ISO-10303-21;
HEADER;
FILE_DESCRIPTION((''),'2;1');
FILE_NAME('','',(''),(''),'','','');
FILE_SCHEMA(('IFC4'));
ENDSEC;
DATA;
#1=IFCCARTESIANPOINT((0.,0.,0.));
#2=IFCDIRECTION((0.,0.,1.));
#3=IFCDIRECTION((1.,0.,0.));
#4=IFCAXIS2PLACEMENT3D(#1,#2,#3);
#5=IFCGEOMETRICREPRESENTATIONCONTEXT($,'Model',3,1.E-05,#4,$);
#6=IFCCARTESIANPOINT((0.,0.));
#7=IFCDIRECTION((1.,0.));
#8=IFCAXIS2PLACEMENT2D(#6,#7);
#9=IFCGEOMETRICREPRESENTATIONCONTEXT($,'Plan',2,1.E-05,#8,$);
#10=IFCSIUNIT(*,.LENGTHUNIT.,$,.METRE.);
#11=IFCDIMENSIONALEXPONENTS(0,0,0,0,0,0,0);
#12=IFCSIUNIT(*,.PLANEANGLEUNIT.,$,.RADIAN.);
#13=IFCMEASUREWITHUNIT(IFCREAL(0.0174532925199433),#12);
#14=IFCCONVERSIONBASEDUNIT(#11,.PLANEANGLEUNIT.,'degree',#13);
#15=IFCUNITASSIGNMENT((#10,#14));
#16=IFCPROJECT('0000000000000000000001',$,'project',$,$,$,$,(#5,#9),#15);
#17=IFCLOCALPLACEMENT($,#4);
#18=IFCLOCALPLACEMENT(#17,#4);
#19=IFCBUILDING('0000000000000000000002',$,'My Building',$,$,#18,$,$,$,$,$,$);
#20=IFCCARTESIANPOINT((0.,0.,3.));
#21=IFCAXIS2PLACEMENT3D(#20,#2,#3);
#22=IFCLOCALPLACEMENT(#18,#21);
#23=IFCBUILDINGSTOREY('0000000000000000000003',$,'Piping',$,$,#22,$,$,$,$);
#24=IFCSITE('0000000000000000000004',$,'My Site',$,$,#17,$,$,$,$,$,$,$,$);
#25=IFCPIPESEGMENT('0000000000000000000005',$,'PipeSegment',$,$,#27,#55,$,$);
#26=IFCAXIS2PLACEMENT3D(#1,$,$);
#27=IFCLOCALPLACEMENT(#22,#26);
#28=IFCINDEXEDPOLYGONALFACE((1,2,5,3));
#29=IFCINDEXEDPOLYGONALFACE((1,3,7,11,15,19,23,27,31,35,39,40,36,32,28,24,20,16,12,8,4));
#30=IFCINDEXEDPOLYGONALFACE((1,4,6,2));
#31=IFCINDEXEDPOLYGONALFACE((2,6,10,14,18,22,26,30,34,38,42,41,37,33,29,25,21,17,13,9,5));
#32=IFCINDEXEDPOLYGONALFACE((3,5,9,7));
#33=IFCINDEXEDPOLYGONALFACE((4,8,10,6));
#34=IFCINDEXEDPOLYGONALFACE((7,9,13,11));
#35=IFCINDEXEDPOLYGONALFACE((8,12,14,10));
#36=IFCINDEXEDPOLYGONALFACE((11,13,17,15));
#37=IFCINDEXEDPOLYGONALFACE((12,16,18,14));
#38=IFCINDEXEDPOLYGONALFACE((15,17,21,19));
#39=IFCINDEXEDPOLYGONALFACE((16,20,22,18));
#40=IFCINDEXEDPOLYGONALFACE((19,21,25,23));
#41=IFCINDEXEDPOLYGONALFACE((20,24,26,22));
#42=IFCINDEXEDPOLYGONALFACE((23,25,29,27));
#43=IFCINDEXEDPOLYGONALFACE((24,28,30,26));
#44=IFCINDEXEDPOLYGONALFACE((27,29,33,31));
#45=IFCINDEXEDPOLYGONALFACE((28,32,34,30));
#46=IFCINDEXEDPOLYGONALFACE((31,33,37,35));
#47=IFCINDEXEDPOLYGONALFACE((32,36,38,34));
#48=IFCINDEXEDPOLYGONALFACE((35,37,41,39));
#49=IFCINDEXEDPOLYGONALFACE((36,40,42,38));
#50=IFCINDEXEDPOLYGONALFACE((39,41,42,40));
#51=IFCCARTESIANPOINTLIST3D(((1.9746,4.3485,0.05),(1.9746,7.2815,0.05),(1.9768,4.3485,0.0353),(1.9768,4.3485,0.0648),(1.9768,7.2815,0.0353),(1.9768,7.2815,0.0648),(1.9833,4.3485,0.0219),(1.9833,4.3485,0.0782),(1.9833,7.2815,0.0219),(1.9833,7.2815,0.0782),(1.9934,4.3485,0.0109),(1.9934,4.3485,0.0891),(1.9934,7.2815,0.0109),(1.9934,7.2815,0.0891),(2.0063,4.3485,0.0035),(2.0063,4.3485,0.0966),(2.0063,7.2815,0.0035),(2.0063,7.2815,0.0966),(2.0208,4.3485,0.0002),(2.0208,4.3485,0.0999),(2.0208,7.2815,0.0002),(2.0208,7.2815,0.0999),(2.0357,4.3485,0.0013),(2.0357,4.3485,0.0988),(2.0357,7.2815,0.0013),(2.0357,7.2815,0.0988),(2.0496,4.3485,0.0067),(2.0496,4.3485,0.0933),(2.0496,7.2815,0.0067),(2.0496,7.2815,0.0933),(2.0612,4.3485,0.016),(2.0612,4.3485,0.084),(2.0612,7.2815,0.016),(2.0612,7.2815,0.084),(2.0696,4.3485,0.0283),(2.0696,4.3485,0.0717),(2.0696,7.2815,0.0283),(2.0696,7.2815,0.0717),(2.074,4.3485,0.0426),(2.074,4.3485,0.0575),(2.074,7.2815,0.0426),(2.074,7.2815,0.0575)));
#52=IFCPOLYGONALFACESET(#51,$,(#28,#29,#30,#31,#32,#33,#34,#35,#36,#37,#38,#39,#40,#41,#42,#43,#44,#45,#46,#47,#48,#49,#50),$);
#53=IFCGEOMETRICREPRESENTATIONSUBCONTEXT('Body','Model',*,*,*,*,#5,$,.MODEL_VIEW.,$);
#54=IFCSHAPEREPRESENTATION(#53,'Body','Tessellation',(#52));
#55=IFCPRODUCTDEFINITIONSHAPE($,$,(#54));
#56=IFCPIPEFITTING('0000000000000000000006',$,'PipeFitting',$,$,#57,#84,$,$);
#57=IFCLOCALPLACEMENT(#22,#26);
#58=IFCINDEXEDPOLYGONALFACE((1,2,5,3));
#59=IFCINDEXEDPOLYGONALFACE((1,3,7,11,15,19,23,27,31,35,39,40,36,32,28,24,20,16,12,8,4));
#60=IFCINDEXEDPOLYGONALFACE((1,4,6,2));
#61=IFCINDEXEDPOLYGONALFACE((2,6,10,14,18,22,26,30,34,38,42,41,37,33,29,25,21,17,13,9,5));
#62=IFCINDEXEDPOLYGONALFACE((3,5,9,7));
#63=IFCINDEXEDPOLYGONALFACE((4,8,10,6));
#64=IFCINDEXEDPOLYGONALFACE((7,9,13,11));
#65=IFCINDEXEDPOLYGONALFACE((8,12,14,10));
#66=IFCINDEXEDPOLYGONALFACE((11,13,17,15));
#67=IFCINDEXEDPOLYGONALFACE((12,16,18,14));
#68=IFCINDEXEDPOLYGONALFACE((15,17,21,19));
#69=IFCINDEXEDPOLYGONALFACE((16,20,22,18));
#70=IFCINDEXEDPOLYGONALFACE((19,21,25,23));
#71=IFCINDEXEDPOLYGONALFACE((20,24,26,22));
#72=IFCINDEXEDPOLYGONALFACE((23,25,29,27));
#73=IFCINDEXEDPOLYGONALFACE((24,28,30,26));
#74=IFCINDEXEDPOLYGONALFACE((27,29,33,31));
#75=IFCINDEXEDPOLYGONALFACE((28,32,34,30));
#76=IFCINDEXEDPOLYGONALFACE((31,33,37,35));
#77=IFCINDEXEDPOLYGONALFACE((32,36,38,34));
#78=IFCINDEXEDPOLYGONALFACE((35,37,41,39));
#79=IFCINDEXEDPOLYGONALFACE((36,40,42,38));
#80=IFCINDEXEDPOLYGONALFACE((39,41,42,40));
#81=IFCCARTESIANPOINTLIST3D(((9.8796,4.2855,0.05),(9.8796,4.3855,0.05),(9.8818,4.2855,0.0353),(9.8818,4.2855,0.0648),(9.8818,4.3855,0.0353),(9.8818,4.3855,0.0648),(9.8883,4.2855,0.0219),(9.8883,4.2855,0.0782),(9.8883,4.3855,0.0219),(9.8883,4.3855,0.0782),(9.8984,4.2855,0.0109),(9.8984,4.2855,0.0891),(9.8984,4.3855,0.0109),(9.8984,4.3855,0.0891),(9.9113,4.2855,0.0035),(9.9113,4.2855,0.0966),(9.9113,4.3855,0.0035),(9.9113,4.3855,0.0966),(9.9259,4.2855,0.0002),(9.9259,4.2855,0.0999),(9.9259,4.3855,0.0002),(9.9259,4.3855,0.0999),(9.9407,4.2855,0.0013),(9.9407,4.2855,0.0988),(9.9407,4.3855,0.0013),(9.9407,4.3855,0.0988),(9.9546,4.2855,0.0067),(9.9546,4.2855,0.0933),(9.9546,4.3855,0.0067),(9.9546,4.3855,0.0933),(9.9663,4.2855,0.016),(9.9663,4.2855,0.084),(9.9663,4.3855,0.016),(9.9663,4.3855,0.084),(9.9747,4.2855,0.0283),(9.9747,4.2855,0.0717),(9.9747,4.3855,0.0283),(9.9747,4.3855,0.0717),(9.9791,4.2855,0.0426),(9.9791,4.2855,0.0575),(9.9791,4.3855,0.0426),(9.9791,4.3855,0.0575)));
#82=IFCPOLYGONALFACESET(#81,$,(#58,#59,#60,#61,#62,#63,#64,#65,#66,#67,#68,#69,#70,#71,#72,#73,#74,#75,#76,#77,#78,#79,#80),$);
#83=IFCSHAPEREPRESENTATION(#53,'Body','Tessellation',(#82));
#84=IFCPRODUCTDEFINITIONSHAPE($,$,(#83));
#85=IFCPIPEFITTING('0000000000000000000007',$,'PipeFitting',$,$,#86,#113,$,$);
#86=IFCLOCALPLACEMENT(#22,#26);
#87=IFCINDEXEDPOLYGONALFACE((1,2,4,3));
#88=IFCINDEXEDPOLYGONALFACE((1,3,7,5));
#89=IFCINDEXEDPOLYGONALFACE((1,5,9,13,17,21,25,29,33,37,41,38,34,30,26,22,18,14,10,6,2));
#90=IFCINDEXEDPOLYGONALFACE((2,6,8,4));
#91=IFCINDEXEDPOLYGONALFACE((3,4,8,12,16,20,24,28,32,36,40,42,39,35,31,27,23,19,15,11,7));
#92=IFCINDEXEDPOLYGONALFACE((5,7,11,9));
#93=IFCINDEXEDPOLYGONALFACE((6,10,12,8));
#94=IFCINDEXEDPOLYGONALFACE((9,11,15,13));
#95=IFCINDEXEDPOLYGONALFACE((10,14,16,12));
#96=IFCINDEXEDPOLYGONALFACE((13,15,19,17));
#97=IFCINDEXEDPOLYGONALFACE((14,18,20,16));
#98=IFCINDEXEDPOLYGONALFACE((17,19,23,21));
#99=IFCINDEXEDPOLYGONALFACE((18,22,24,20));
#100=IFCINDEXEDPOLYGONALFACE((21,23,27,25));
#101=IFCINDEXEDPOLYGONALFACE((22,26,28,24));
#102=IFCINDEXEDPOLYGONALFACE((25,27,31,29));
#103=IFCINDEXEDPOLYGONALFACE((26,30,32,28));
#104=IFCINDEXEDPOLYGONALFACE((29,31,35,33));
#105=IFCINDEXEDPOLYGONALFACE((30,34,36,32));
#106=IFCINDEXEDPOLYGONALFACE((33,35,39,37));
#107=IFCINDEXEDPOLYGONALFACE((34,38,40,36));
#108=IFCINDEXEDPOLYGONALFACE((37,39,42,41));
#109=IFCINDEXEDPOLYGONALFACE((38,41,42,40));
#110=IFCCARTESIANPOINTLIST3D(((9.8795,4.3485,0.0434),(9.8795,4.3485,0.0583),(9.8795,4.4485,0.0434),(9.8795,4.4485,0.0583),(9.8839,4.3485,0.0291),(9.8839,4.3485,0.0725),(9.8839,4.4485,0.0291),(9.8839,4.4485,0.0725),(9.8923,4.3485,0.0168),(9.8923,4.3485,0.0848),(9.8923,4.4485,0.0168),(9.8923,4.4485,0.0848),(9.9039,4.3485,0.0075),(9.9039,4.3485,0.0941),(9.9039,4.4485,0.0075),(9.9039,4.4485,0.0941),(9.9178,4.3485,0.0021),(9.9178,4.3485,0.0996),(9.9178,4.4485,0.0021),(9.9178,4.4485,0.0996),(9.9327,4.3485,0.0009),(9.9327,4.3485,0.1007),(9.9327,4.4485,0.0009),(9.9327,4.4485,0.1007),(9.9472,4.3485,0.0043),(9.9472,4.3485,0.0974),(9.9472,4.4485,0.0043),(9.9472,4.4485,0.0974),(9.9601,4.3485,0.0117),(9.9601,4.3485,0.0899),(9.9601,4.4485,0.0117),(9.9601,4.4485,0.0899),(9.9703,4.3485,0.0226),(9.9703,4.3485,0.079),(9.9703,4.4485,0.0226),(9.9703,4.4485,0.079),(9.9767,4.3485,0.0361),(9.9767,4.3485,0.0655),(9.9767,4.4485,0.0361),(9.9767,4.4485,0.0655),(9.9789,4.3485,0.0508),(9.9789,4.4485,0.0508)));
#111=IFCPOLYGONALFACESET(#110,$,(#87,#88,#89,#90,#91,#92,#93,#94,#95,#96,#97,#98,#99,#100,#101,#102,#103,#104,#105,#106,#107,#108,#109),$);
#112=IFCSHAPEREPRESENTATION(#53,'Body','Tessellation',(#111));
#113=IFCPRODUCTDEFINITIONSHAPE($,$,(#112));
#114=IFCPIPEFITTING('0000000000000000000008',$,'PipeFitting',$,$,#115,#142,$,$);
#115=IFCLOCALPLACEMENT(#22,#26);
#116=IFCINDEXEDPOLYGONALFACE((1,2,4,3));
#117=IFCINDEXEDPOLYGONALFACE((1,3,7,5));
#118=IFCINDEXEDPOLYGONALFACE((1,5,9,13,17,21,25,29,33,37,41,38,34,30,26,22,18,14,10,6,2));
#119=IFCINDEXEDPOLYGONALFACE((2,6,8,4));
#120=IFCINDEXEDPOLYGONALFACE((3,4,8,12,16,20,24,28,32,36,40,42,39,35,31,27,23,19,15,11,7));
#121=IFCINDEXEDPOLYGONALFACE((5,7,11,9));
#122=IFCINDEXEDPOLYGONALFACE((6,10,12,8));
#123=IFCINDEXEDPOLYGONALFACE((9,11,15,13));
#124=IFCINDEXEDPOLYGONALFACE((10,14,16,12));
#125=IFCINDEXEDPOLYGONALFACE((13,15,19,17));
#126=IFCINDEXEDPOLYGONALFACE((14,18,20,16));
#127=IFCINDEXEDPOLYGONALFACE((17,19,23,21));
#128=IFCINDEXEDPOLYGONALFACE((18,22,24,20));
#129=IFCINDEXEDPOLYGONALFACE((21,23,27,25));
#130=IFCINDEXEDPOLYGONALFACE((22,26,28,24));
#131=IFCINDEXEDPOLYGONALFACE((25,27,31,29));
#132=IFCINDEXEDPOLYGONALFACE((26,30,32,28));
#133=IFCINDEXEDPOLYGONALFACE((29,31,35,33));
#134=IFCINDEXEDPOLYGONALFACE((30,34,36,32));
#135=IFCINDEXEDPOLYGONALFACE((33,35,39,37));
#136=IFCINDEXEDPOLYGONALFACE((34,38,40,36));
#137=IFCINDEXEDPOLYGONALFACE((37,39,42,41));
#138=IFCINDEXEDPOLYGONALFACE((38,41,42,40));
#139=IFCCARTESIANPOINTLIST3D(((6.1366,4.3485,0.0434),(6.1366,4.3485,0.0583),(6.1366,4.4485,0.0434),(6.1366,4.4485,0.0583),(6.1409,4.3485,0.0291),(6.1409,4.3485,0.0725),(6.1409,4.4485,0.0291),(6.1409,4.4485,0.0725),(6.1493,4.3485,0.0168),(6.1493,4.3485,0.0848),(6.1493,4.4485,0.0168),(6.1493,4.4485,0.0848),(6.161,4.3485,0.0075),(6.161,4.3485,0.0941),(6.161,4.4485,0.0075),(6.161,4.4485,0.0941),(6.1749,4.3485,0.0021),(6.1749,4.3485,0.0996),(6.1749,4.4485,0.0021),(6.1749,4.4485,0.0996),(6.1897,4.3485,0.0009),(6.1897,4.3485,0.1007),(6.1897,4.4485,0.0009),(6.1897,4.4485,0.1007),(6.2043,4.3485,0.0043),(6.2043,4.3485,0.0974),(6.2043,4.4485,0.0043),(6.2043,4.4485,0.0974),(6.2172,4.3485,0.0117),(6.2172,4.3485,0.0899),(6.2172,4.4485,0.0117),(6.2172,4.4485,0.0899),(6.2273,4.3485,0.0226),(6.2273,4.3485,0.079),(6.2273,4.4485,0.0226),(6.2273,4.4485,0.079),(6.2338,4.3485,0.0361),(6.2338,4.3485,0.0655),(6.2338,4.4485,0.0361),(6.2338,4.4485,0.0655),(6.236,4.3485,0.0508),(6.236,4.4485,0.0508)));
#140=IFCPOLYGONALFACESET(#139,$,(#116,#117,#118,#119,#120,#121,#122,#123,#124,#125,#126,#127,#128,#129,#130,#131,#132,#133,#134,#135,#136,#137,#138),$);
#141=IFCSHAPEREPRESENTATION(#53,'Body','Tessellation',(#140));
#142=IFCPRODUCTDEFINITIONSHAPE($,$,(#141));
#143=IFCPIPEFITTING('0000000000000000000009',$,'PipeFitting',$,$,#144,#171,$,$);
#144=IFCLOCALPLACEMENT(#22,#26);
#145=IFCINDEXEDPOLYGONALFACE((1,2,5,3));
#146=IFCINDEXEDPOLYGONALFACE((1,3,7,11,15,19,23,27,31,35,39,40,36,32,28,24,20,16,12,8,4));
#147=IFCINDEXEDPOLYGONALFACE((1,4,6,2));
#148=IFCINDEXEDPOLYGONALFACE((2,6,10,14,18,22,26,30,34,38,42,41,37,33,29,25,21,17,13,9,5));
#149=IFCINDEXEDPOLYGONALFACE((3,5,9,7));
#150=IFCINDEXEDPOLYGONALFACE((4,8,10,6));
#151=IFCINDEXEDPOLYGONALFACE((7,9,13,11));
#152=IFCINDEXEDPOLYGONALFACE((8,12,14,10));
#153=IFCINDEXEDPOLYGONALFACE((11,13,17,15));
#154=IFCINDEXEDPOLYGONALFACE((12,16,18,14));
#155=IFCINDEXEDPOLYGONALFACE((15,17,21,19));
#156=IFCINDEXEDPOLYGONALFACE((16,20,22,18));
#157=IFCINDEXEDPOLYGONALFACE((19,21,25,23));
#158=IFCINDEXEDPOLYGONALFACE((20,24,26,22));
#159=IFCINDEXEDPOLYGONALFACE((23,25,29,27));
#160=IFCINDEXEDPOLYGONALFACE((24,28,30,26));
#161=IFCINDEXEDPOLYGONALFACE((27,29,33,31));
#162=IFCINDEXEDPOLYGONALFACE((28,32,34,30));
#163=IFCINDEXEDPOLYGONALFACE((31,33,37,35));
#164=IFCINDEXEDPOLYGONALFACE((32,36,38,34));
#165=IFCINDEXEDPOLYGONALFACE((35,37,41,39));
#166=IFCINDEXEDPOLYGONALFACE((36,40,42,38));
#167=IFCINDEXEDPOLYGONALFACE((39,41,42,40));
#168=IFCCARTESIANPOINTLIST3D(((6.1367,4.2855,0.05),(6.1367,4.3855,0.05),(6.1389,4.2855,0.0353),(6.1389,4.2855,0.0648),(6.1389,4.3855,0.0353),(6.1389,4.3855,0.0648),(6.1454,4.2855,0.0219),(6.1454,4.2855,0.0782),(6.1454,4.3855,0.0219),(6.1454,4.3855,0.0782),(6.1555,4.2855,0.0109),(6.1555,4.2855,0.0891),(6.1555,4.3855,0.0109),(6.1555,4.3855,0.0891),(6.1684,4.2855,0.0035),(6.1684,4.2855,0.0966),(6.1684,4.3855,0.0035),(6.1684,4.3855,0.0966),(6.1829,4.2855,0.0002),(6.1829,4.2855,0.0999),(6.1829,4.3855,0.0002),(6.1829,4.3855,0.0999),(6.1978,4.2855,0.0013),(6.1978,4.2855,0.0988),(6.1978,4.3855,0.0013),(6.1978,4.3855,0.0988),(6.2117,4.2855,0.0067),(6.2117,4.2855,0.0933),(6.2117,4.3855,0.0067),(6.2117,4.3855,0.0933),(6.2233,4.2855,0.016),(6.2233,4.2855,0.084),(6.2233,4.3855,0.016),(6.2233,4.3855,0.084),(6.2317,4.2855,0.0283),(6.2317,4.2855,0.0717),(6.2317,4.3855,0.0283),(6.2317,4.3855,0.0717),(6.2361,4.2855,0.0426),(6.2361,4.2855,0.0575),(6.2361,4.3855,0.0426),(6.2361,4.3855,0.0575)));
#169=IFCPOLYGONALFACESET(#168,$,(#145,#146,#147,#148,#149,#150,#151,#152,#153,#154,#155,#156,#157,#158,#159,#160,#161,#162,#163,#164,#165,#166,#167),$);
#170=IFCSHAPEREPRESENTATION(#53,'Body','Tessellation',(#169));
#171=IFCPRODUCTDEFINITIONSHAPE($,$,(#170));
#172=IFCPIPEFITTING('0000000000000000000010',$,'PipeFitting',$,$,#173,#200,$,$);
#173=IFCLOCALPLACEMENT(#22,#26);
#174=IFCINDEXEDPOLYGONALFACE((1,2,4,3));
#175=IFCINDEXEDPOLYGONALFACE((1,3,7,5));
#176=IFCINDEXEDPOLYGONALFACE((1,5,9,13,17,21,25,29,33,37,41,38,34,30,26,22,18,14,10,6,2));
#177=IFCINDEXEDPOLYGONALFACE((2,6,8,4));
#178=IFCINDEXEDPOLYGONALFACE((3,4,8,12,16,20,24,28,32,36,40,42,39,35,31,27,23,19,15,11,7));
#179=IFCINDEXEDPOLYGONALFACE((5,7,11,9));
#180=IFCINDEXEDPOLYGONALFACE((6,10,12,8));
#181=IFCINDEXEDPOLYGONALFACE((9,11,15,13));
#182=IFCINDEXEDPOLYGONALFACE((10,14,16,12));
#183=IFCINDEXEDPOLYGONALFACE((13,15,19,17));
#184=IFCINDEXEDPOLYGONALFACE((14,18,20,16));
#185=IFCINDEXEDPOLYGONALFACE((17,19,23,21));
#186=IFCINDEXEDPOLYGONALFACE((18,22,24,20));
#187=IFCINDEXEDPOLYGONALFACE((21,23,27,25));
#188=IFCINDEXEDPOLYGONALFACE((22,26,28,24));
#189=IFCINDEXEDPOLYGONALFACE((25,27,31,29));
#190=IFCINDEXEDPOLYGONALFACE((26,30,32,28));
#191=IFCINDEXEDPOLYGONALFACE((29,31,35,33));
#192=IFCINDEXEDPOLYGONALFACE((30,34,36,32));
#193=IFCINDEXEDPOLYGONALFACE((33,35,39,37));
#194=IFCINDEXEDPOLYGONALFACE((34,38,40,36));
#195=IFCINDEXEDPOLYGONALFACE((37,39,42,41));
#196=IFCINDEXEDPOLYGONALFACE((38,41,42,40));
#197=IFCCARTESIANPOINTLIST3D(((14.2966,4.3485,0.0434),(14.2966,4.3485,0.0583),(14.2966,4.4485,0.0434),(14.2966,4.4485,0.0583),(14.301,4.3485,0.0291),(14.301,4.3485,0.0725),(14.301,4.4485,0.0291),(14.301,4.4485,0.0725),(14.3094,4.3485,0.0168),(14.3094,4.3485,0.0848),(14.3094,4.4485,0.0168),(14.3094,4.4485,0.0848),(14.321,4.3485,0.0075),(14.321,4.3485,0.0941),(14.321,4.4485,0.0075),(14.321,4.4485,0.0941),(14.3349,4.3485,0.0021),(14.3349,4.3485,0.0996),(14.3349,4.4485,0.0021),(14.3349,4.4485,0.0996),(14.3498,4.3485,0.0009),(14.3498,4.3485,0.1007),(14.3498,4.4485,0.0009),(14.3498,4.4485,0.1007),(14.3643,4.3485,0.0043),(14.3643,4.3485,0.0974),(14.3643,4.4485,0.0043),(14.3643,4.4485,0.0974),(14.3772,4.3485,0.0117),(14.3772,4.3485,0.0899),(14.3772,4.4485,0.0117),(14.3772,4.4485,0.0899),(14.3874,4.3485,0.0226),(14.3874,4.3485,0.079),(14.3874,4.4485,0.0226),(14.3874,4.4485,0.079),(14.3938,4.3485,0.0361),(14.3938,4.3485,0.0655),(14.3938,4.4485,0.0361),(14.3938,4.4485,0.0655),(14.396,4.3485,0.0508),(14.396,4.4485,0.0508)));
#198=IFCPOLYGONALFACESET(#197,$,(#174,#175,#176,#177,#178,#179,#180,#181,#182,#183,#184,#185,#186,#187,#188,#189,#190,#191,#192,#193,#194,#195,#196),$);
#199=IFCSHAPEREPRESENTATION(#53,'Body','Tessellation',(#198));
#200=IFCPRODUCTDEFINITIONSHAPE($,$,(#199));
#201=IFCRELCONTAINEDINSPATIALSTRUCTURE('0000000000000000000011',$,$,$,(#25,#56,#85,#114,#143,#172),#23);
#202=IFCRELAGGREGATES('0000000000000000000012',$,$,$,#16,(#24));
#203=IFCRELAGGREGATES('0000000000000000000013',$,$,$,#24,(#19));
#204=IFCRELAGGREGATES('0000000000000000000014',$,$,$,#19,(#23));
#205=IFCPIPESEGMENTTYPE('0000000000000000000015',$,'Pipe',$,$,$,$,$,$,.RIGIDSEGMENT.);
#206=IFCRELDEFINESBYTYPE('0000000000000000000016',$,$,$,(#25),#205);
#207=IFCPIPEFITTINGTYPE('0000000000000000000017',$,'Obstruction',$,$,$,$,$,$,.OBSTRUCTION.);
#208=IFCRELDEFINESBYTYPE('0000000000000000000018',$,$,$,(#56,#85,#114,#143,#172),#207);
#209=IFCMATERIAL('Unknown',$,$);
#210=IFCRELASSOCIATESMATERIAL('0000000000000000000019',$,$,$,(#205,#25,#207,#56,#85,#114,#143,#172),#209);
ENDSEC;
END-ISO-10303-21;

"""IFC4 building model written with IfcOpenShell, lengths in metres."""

from ifc_helpers import new_model, entity, si_unit, converted_unit, frame, origin_with_axes, origin_2d_with_axis, place, context, subcontext, project, spatial, circle, extrude, material, material_profile, profile_set, profile_usage, type_object, element, save


model = new_model("IFC4")

# Units and contexts
model_context = context("Model", 3, precision=1e-05, world=origin_with_axes())
plan_context = context("Plan", 2, precision=1e-05, world=origin_2d_with_axis())
body_context = subcontext(model_context, "Body", "Model", "MODEL_VIEW")
ifc_project = project(units=[si_unit("LENGTHUNIT", "METRE"), converted_unit("PLANEANGLEUNIT", "degree", entity("IfcReal", 0.0174532925199433), si_unit("PLANEANGLEUNIT", "RADIAN"), dimensions=[0, 0, 0, 0, 0, 0, 0])], contexts=[model_context, plan_context])

# Site, building, storey
site_placement = place(None, origin_with_axes())
site = spatial("IfcSite", under=ifc_project, at=site_placement, Name="My Site")
building_placement = place(site_placement, origin_with_axes())
building = spatial("IfcBuilding", under=site, at=building_placement, Name="My Building")
storey_placement = place(building_placement, frame((0.0, 0.0, 3.0), z_axis=(0.0, 0.0, 1.0), x_axis=(1.0, 0.0, 0.0)))
storey = spatial("IfcBuildingStorey", under=building, at=storey_placement, Name="Piping")

# Pipe segment
ifc_material = material(Name="Unknown")
ifc_material_profile_1 = material_profile(ifc_material, circle(Radius=0.05))
ifc_profile_set_1 = profile_set([ifc_material_profile_1])
pipe_segment_type = type_object("IfcPipeSegmentType", Name="Pipe", PredefinedType="RIGIDSEGMENT", material=ifc_profile_set_1)
ifc_profile_usage_1 = profile_usage(ifc_profile_set_1, cardinal=5)
pipe_segment_1_placement = place(storey_placement, frame((2.0246, 4.3485, 0.05), z_axis=(0.0, 1.0, 0.0), x_axis=(-1.0, 0.0, 0.0)))
element("IfcPipeSegment", 1, at=pipe_segment_1_placement, inside=storey, type_object=pipe_segment_type, material=ifc_profile_usage_1, Name="PipeSegment", context=body_context, shape_type="SweptSolid", body=[
    extrude(circle(Radius=0.05), origin_with_axes(), (0.0, 0.0, 1.0), 2.933),
])

# Pipe fittings
ifc_material_profile_2 = material_profile(ifc_material, circle(Radius=0.05))
ifc_profile_set_2 = profile_set([ifc_material_profile_2])
ifc_profile_usage_2 = profile_usage(ifc_profile_set_2, cardinal=5)
pipe_fitting_type = type_object("IfcPipeFittingType", Name="Obstruction", PredefinedType="OBSTRUCTION", material=ifc_profile_set_2)
pipe_fitting_1_placement = place(storey_placement, frame((9.9296, 4.2855, 0.05), z_axis=(0.0, 1.0, 0.0), x_axis=(-1.0, 0.0, 0.0)))
element("IfcPipeFitting", 2, at=pipe_fitting_1_placement, inside=storey, type_object=pipe_fitting_type, material=ifc_profile_usage_2, Name="PipeFitting", context=body_context, shape_type="SweptSolid", body=[
    extrude(circle(Radius=0.05), origin_with_axes(), (0.0, 0.0, 1.0), 0.1),
])
ifc_profile_usage_3 = profile_usage(ifc_profile_set_2, cardinal=5)
pipe_fitting_2_placement = place(storey_placement, frame((9.9289, 4.3485, 0.0508), z_axis=(0.0, 1.0, 0.0), x_axis=(1.0, 0.0, 0.0)))
element("IfcPipeFitting", 3, at=pipe_fitting_2_placement, inside=storey, type_object=pipe_fitting_type, material=ifc_profile_usage_3, Name="PipeFitting", context=body_context, shape_type="SweptSolid", body=[
    extrude(circle(Radius=0.05), origin_with_axes(), (0.0, 0.0, 1.0), 0.1),
])
ifc_profile_usage_4 = profile_usage(ifc_profile_set_2, cardinal=5)
pipe_fitting_3_placement = place(storey_placement, frame((6.186, 4.3485, 0.0508), z_axis=(0.0, 1.0, 0.0), x_axis=(1.0, 0.0, 0.0)))
element("IfcPipeFitting", 4, at=pipe_fitting_3_placement, inside=storey, type_object=pipe_fitting_type, material=ifc_profile_usage_4, Name="PipeFitting", context=body_context, shape_type="SweptSolid", body=[
    extrude(circle(Radius=0.05), origin_with_axes(), (0.0, 0.0, 1.0), 0.1),
])
ifc_profile_usage_5 = profile_usage(ifc_profile_set_2, cardinal=5)
pipe_fitting_4_placement = place(storey_placement, frame((6.1867, 4.2855, 0.05), z_axis=(0.0, 1.0, 0.0), x_axis=(-1.0, 0.0, 0.0)))
element("IfcPipeFitting", 5, at=pipe_fitting_4_placement, inside=storey, type_object=pipe_fitting_type, material=ifc_profile_usage_5, Name="PipeFitting", context=body_context, shape_type="SweptSolid", body=[
    extrude(circle(Radius=0.05), origin_with_axes(), (0.0, 0.0, 1.0), 0.1),
])
ifc_profile_usage_6 = profile_usage(ifc_profile_set_2, cardinal=5)
pipe_fitting_5_placement = place(storey_placement, frame((14.346, 4.3485, 0.0508), z_axis=(0.0, 1.0, 0.0), x_axis=(1.0, 0.0, 0.0)))
element("IfcPipeFitting", 6, at=pipe_fitting_5_placement, inside=storey, type_object=pipe_fitting_type, material=ifc_profile_usage_6, Name="PipeFitting", context=body_context, shape_type="SweptSolid", body=[
    extrude(circle(Radius=0.05), origin_with_axes(), (0.0, 0.0, 1.0), 0.1),
])

save(model, "model.ifc")
